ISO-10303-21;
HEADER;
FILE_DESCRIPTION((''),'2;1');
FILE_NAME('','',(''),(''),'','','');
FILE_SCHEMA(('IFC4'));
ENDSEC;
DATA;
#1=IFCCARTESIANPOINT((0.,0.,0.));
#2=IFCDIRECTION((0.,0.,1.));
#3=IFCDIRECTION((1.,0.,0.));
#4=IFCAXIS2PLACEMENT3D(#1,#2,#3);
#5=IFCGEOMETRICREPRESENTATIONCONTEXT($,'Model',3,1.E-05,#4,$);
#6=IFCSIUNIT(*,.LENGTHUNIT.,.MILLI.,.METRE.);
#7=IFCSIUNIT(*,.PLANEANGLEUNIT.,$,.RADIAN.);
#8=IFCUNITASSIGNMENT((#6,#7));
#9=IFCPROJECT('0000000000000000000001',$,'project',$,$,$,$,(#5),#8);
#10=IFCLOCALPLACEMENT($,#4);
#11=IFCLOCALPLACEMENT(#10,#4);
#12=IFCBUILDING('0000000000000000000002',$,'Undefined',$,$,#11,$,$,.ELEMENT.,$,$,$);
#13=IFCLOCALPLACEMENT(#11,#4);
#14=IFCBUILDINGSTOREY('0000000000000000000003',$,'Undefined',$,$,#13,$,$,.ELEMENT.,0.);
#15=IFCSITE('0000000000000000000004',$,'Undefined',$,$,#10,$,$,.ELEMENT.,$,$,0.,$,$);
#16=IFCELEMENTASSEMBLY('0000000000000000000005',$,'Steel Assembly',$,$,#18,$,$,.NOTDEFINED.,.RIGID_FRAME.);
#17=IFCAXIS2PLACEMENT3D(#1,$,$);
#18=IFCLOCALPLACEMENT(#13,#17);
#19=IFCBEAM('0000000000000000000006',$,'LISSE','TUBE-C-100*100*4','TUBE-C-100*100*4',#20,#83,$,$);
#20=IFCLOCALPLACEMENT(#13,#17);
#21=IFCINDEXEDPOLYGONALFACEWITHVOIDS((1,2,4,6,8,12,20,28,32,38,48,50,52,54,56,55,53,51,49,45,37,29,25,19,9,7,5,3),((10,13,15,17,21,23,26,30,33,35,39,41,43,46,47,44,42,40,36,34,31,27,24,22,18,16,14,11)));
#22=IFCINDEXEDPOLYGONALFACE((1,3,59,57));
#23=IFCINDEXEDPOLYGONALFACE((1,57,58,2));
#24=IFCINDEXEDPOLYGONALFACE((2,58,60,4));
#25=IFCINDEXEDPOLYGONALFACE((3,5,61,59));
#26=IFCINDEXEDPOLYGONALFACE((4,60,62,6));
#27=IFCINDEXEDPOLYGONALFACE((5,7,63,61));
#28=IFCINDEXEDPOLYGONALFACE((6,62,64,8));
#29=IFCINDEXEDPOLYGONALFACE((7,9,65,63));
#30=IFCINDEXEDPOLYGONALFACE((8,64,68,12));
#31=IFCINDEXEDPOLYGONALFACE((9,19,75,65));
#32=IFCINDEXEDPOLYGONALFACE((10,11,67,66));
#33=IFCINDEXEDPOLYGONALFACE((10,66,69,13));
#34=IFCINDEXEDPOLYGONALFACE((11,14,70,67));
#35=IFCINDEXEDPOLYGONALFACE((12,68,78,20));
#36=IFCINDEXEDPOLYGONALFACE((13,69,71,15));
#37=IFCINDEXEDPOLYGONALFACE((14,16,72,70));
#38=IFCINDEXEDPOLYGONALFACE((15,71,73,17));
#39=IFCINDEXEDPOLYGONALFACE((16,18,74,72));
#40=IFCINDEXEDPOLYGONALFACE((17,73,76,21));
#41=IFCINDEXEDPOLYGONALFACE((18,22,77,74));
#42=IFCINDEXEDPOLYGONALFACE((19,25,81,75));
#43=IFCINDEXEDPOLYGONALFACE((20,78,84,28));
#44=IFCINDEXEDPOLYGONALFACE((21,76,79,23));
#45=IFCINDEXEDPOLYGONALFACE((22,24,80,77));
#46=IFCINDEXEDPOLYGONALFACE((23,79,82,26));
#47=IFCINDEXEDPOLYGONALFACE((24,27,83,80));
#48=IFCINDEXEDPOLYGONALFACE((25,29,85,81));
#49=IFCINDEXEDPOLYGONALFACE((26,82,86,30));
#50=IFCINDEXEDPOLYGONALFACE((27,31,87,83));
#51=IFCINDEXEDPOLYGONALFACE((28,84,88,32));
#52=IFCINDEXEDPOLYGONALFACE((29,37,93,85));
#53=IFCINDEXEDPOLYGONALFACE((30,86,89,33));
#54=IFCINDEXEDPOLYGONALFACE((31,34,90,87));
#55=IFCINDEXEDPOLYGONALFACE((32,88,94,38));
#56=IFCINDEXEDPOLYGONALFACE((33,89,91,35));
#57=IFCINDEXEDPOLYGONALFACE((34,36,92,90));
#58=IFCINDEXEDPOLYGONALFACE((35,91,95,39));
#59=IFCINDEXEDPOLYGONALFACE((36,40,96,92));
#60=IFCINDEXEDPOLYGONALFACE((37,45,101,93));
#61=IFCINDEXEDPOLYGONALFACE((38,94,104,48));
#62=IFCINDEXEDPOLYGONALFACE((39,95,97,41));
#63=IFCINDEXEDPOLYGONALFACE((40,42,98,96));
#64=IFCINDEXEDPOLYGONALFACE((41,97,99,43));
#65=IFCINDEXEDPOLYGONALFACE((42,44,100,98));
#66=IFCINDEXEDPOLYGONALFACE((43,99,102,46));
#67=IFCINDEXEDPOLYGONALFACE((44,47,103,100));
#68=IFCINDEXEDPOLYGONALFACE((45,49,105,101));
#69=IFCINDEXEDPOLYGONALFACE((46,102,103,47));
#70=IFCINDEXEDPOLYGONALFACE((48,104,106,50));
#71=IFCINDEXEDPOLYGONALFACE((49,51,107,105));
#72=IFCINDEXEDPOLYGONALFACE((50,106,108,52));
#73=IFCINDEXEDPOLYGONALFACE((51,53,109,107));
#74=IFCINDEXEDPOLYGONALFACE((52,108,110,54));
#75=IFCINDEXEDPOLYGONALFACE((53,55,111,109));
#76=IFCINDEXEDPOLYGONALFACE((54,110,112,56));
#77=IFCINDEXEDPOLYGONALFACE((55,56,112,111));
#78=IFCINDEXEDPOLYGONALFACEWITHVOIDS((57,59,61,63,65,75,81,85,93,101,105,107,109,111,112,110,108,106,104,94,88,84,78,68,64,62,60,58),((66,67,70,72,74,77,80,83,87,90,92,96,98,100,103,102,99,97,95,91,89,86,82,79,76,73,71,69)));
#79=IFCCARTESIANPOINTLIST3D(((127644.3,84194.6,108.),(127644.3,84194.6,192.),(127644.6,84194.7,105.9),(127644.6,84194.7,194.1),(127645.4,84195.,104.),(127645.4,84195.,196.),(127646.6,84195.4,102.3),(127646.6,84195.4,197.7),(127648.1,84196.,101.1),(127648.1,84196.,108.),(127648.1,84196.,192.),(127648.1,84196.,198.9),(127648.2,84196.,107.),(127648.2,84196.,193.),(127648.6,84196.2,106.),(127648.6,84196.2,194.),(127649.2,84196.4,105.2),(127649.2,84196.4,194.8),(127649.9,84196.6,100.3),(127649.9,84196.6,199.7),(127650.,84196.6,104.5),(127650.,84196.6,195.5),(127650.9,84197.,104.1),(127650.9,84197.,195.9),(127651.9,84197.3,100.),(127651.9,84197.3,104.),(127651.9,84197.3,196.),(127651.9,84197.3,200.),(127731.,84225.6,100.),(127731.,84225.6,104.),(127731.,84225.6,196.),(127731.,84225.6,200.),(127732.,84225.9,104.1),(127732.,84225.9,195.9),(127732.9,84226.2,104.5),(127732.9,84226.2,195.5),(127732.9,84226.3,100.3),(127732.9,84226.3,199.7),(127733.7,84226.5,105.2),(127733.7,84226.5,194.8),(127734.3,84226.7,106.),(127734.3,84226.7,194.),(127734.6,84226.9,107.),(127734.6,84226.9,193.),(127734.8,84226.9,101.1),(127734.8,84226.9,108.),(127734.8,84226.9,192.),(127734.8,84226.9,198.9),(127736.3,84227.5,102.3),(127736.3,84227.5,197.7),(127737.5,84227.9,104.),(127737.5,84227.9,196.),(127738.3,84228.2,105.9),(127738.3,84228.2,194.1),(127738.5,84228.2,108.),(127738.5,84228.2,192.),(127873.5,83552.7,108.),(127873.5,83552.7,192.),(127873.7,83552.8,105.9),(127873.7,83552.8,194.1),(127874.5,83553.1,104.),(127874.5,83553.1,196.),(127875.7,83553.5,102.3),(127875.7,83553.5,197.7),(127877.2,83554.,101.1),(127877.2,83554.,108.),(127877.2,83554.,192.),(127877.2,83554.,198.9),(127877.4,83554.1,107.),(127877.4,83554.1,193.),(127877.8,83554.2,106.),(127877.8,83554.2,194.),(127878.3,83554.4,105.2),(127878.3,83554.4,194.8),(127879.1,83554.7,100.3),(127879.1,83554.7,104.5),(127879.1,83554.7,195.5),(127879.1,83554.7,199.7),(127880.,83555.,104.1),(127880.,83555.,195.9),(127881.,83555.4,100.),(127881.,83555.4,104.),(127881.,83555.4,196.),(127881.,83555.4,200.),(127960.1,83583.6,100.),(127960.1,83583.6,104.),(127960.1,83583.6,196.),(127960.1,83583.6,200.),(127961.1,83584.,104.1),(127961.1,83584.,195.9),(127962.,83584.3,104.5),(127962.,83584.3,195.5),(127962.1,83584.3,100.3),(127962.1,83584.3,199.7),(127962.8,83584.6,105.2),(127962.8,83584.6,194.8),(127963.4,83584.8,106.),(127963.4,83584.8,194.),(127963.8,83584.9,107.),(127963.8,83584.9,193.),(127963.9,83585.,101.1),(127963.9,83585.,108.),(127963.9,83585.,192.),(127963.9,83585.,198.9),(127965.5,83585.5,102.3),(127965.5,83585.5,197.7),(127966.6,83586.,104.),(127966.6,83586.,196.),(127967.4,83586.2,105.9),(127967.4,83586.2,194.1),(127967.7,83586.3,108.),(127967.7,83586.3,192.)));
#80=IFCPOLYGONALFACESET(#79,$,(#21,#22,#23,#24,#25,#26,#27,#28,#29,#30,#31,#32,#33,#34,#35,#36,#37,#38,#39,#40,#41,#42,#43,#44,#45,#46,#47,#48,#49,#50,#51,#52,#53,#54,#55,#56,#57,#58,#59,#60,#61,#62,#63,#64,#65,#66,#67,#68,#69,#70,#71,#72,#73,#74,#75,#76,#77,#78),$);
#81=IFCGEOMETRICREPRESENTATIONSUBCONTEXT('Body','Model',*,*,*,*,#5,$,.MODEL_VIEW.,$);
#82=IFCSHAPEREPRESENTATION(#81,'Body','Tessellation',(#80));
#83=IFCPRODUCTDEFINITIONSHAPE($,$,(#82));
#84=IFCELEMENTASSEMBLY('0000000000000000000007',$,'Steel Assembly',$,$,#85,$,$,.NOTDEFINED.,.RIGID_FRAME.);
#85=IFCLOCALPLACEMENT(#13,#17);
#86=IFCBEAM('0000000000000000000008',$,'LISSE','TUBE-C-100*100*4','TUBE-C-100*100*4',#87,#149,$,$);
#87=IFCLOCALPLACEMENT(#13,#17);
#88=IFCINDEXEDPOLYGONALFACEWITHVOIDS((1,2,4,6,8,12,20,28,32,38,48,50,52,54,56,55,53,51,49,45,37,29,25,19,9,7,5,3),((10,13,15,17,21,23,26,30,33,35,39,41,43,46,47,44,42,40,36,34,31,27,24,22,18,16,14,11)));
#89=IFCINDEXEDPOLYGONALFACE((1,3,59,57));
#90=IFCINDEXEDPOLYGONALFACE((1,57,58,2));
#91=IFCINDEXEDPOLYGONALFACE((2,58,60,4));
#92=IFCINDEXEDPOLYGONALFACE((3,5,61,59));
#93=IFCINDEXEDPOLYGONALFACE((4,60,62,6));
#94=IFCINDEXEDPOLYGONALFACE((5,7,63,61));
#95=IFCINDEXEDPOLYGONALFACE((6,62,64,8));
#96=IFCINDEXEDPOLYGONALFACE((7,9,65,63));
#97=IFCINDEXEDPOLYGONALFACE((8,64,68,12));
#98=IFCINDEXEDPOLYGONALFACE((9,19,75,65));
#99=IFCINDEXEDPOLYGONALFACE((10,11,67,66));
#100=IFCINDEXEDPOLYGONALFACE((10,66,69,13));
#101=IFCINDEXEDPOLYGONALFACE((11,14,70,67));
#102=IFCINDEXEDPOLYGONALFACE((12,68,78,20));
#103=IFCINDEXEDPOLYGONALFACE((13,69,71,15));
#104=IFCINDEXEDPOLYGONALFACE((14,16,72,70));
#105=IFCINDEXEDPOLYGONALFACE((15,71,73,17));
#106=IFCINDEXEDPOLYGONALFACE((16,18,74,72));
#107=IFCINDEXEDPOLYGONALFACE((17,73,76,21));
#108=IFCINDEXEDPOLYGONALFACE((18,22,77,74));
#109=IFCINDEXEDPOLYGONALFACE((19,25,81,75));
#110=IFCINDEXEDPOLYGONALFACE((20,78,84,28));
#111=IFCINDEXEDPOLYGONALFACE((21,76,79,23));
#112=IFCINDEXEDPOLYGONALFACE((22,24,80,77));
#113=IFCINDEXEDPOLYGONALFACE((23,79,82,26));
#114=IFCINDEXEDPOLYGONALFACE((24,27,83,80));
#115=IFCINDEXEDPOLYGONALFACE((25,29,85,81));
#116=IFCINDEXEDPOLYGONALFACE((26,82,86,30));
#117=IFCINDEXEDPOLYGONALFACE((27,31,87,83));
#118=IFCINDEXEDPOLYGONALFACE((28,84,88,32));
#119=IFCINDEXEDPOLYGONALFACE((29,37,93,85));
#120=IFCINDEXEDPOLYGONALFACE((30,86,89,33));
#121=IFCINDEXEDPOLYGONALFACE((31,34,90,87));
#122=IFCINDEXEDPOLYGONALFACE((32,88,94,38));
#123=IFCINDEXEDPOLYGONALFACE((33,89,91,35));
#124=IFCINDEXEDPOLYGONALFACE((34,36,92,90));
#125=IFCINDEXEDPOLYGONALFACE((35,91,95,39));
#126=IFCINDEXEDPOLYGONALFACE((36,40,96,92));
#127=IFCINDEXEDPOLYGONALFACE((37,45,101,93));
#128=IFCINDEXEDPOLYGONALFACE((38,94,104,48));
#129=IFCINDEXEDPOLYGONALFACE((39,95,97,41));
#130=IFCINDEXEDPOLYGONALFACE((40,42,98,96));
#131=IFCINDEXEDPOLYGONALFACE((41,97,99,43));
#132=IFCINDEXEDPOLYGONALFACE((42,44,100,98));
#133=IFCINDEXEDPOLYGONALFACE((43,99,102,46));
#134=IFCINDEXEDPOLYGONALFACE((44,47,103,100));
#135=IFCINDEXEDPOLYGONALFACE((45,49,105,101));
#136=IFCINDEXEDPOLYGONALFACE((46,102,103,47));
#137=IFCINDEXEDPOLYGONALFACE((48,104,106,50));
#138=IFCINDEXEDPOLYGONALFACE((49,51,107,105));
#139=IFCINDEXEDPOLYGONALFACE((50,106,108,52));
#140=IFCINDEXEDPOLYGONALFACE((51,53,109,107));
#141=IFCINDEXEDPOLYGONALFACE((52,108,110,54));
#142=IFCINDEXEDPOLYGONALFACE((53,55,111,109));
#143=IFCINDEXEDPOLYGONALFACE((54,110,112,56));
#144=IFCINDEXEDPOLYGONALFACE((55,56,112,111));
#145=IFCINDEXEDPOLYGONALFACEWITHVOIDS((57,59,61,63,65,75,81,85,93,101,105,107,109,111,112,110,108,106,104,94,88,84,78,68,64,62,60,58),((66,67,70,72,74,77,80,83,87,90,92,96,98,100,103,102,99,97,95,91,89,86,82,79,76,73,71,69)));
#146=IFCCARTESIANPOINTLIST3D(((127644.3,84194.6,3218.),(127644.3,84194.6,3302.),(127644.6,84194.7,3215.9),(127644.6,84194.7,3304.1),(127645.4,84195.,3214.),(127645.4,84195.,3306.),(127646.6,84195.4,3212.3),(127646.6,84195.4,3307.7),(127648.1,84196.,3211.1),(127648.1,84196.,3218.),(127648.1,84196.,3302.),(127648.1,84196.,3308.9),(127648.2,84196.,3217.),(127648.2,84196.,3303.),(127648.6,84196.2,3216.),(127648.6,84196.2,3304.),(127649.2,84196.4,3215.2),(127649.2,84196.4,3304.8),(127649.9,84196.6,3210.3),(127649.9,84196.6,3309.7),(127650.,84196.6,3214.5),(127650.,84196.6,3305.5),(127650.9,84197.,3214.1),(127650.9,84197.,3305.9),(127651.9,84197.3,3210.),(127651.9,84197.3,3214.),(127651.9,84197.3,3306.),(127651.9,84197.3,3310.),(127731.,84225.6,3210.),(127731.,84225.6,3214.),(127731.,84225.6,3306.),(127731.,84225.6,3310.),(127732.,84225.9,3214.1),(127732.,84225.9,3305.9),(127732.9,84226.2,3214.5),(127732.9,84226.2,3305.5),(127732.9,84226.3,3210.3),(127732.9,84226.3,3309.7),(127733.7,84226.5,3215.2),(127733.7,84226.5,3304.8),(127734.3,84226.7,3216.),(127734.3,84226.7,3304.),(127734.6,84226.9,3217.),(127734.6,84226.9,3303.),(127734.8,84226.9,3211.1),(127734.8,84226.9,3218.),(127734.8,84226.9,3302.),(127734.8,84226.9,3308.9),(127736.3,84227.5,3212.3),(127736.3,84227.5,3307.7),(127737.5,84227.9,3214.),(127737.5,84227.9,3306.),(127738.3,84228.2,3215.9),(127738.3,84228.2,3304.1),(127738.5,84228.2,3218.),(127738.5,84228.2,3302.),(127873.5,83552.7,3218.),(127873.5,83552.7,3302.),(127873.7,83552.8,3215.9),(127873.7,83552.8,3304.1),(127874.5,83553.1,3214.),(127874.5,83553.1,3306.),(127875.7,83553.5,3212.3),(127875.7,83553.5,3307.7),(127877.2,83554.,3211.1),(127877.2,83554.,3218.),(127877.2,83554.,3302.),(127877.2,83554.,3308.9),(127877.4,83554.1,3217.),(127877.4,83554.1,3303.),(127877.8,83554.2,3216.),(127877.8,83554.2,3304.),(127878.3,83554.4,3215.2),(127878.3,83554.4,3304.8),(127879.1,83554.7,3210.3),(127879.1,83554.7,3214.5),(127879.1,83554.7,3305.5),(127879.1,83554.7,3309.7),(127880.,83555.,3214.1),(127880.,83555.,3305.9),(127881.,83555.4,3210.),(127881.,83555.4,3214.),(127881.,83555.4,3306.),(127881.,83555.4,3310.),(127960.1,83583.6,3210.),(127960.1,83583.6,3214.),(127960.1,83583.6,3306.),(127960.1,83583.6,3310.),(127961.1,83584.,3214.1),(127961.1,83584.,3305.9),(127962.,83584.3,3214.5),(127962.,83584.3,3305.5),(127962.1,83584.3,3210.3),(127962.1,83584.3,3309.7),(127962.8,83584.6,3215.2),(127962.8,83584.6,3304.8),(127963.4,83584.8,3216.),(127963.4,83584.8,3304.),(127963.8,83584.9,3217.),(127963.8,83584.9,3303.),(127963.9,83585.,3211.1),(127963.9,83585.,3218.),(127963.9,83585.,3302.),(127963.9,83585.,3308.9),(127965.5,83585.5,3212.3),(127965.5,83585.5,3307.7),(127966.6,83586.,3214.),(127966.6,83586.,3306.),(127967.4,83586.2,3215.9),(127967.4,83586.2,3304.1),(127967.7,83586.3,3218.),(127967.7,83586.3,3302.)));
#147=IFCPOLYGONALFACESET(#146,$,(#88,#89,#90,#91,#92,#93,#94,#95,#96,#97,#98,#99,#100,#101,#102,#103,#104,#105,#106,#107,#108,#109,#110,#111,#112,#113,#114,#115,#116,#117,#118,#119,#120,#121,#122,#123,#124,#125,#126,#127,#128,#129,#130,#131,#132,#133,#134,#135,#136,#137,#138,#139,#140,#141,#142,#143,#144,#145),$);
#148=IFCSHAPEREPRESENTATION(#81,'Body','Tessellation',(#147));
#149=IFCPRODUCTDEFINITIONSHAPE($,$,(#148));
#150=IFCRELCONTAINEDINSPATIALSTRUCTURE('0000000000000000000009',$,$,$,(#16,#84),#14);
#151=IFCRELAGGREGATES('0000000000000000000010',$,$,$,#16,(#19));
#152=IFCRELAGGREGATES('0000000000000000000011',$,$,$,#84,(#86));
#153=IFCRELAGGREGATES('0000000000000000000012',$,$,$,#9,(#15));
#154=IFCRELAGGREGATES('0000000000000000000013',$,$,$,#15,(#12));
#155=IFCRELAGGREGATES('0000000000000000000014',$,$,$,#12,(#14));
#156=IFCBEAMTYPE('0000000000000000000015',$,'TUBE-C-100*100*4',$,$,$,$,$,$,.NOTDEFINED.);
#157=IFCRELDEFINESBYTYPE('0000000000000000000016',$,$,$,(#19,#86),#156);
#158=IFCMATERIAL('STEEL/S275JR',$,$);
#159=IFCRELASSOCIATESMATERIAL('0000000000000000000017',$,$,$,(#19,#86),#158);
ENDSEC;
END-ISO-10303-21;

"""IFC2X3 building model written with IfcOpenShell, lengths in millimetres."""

from ifc_helpers import new_model, si_unit, frame, origin_with_axes, origin_2d_with_axis, place, context, subcontext, project, spatial, hollow_rectangle, extrude, material, type_object, element, aggregate, save


model = new_model("IFC2X3")

# Units and contexts
model_context = context("Model", 3, precision=1e-05, world=origin_with_axes())
body_context = subcontext(model_context, "Body", "Model", "MODEL_VIEW")
ifc_project = project(units=[si_unit("LENGTHUNIT", "METRE", prefix="MILLI"), si_unit("PLANEANGLEUNIT", "RADIAN")], contexts=[model_context])

# Site, building, storey
site_placement = place(None, origin_with_axes())
site = spatial("IfcSite", under=ifc_project, at=site_placement, Name="Undefined", CompositionType="ELEMENT", RefElevation=0.0)
building_placement = place(site_placement, origin_with_axes())
building = spatial("IfcBuilding", under=site, at=building_placement, Name="Undefined", CompositionType="ELEMENT")
storey_placement = place(building_placement, origin_with_axes())
storey = spatial("IfcBuildingStorey", under=building, at=storey_placement, Name="Undefined", CompositionType="ELEMENT", Elevation=0.0)

# Shared definitions
ifc_material = material(Name="STEEL/S275JR")

# Element assemblies, beams
beam_type_1 = type_object("IfcBeamType", Name="TUBE-C-100*100*4", PredefinedType="NOTDEFINED")
assembly_1_placement = place(storey_placement, origin_with_axes())
assembly_1 = element("IfcElementAssembly", 1, at=assembly_1_placement, inside=storey, Name="Steel Assembly", AssemblyPlace="NOTDEFINED", PredefinedType="RIGID_FRAME")
beam_1_placement = place(assembly_1_placement, frame((127920.6, 83569.5, 150.0), z_axis=(0.941802, 0.336168, 0.0), x_axis=(-0.336168, 0.941802, 0.0)))
beam_1 = element("IfcBeam", 2, at=beam_1_placement, type_object=beam_type_1, material=ifc_material, Name="LISSE", Description="TUBE-C-100*100*4", ObjectType="TUBE-C-100*100*4", context=body_context, shape_type="SweptSolid", body=[
    extrude(hollow_rectangle(XDim=100.0, YDim=100.0, WallThickness=4.0, InnerFilletRadius=4.0, OuterFilletRadius=8.0, at=origin_2d_with_axis()), frame((681.6, 0.0, 0.0), z_axis=(-1.0, 0.0, 0.0), x_axis=(0.0, -1.0, 0.0)), (0.0, 0.0, 1.0), 681.6),
])
aggregate(assembly_1, [beam_1])
assembly_2_placement = place(storey_placement, origin_with_axes())
assembly_2 = element("IfcElementAssembly", 3, at=assembly_2_placement, inside=storey, Name="Steel Assembly", AssemblyPlace="NOTDEFINED", PredefinedType="RIGID_FRAME")
beam_2_placement = place(assembly_2_placement, frame((127920.6, 83569.5, 3260.0), z_axis=(0.941802, 0.336168, 0.0), x_axis=(-0.336168, 0.941802, 0.0)))
beam_2 = element("IfcBeam", 4, at=beam_2_placement, type_object=beam_type_1, material=ifc_material, Name="LISSE", Description="TUBE-C-100*100*4", ObjectType="TUBE-C-100*100*4", context=body_context, shape_type="SweptSolid", body=[
    extrude(hollow_rectangle(XDim=100.0, YDim=100.0, WallThickness=4.0, InnerFilletRadius=4.0, OuterFilletRadius=8.0, at=origin_2d_with_axis()), frame((681.6, 0.0, 0.0), z_axis=(-1.0, 0.0, 0.0), x_axis=(0.0, -1.0, 0.0)), (0.0, 0.0, 1.0), 681.6),
])
aggregate(assembly_2, [beam_2])

save(model, "model.ifc")
